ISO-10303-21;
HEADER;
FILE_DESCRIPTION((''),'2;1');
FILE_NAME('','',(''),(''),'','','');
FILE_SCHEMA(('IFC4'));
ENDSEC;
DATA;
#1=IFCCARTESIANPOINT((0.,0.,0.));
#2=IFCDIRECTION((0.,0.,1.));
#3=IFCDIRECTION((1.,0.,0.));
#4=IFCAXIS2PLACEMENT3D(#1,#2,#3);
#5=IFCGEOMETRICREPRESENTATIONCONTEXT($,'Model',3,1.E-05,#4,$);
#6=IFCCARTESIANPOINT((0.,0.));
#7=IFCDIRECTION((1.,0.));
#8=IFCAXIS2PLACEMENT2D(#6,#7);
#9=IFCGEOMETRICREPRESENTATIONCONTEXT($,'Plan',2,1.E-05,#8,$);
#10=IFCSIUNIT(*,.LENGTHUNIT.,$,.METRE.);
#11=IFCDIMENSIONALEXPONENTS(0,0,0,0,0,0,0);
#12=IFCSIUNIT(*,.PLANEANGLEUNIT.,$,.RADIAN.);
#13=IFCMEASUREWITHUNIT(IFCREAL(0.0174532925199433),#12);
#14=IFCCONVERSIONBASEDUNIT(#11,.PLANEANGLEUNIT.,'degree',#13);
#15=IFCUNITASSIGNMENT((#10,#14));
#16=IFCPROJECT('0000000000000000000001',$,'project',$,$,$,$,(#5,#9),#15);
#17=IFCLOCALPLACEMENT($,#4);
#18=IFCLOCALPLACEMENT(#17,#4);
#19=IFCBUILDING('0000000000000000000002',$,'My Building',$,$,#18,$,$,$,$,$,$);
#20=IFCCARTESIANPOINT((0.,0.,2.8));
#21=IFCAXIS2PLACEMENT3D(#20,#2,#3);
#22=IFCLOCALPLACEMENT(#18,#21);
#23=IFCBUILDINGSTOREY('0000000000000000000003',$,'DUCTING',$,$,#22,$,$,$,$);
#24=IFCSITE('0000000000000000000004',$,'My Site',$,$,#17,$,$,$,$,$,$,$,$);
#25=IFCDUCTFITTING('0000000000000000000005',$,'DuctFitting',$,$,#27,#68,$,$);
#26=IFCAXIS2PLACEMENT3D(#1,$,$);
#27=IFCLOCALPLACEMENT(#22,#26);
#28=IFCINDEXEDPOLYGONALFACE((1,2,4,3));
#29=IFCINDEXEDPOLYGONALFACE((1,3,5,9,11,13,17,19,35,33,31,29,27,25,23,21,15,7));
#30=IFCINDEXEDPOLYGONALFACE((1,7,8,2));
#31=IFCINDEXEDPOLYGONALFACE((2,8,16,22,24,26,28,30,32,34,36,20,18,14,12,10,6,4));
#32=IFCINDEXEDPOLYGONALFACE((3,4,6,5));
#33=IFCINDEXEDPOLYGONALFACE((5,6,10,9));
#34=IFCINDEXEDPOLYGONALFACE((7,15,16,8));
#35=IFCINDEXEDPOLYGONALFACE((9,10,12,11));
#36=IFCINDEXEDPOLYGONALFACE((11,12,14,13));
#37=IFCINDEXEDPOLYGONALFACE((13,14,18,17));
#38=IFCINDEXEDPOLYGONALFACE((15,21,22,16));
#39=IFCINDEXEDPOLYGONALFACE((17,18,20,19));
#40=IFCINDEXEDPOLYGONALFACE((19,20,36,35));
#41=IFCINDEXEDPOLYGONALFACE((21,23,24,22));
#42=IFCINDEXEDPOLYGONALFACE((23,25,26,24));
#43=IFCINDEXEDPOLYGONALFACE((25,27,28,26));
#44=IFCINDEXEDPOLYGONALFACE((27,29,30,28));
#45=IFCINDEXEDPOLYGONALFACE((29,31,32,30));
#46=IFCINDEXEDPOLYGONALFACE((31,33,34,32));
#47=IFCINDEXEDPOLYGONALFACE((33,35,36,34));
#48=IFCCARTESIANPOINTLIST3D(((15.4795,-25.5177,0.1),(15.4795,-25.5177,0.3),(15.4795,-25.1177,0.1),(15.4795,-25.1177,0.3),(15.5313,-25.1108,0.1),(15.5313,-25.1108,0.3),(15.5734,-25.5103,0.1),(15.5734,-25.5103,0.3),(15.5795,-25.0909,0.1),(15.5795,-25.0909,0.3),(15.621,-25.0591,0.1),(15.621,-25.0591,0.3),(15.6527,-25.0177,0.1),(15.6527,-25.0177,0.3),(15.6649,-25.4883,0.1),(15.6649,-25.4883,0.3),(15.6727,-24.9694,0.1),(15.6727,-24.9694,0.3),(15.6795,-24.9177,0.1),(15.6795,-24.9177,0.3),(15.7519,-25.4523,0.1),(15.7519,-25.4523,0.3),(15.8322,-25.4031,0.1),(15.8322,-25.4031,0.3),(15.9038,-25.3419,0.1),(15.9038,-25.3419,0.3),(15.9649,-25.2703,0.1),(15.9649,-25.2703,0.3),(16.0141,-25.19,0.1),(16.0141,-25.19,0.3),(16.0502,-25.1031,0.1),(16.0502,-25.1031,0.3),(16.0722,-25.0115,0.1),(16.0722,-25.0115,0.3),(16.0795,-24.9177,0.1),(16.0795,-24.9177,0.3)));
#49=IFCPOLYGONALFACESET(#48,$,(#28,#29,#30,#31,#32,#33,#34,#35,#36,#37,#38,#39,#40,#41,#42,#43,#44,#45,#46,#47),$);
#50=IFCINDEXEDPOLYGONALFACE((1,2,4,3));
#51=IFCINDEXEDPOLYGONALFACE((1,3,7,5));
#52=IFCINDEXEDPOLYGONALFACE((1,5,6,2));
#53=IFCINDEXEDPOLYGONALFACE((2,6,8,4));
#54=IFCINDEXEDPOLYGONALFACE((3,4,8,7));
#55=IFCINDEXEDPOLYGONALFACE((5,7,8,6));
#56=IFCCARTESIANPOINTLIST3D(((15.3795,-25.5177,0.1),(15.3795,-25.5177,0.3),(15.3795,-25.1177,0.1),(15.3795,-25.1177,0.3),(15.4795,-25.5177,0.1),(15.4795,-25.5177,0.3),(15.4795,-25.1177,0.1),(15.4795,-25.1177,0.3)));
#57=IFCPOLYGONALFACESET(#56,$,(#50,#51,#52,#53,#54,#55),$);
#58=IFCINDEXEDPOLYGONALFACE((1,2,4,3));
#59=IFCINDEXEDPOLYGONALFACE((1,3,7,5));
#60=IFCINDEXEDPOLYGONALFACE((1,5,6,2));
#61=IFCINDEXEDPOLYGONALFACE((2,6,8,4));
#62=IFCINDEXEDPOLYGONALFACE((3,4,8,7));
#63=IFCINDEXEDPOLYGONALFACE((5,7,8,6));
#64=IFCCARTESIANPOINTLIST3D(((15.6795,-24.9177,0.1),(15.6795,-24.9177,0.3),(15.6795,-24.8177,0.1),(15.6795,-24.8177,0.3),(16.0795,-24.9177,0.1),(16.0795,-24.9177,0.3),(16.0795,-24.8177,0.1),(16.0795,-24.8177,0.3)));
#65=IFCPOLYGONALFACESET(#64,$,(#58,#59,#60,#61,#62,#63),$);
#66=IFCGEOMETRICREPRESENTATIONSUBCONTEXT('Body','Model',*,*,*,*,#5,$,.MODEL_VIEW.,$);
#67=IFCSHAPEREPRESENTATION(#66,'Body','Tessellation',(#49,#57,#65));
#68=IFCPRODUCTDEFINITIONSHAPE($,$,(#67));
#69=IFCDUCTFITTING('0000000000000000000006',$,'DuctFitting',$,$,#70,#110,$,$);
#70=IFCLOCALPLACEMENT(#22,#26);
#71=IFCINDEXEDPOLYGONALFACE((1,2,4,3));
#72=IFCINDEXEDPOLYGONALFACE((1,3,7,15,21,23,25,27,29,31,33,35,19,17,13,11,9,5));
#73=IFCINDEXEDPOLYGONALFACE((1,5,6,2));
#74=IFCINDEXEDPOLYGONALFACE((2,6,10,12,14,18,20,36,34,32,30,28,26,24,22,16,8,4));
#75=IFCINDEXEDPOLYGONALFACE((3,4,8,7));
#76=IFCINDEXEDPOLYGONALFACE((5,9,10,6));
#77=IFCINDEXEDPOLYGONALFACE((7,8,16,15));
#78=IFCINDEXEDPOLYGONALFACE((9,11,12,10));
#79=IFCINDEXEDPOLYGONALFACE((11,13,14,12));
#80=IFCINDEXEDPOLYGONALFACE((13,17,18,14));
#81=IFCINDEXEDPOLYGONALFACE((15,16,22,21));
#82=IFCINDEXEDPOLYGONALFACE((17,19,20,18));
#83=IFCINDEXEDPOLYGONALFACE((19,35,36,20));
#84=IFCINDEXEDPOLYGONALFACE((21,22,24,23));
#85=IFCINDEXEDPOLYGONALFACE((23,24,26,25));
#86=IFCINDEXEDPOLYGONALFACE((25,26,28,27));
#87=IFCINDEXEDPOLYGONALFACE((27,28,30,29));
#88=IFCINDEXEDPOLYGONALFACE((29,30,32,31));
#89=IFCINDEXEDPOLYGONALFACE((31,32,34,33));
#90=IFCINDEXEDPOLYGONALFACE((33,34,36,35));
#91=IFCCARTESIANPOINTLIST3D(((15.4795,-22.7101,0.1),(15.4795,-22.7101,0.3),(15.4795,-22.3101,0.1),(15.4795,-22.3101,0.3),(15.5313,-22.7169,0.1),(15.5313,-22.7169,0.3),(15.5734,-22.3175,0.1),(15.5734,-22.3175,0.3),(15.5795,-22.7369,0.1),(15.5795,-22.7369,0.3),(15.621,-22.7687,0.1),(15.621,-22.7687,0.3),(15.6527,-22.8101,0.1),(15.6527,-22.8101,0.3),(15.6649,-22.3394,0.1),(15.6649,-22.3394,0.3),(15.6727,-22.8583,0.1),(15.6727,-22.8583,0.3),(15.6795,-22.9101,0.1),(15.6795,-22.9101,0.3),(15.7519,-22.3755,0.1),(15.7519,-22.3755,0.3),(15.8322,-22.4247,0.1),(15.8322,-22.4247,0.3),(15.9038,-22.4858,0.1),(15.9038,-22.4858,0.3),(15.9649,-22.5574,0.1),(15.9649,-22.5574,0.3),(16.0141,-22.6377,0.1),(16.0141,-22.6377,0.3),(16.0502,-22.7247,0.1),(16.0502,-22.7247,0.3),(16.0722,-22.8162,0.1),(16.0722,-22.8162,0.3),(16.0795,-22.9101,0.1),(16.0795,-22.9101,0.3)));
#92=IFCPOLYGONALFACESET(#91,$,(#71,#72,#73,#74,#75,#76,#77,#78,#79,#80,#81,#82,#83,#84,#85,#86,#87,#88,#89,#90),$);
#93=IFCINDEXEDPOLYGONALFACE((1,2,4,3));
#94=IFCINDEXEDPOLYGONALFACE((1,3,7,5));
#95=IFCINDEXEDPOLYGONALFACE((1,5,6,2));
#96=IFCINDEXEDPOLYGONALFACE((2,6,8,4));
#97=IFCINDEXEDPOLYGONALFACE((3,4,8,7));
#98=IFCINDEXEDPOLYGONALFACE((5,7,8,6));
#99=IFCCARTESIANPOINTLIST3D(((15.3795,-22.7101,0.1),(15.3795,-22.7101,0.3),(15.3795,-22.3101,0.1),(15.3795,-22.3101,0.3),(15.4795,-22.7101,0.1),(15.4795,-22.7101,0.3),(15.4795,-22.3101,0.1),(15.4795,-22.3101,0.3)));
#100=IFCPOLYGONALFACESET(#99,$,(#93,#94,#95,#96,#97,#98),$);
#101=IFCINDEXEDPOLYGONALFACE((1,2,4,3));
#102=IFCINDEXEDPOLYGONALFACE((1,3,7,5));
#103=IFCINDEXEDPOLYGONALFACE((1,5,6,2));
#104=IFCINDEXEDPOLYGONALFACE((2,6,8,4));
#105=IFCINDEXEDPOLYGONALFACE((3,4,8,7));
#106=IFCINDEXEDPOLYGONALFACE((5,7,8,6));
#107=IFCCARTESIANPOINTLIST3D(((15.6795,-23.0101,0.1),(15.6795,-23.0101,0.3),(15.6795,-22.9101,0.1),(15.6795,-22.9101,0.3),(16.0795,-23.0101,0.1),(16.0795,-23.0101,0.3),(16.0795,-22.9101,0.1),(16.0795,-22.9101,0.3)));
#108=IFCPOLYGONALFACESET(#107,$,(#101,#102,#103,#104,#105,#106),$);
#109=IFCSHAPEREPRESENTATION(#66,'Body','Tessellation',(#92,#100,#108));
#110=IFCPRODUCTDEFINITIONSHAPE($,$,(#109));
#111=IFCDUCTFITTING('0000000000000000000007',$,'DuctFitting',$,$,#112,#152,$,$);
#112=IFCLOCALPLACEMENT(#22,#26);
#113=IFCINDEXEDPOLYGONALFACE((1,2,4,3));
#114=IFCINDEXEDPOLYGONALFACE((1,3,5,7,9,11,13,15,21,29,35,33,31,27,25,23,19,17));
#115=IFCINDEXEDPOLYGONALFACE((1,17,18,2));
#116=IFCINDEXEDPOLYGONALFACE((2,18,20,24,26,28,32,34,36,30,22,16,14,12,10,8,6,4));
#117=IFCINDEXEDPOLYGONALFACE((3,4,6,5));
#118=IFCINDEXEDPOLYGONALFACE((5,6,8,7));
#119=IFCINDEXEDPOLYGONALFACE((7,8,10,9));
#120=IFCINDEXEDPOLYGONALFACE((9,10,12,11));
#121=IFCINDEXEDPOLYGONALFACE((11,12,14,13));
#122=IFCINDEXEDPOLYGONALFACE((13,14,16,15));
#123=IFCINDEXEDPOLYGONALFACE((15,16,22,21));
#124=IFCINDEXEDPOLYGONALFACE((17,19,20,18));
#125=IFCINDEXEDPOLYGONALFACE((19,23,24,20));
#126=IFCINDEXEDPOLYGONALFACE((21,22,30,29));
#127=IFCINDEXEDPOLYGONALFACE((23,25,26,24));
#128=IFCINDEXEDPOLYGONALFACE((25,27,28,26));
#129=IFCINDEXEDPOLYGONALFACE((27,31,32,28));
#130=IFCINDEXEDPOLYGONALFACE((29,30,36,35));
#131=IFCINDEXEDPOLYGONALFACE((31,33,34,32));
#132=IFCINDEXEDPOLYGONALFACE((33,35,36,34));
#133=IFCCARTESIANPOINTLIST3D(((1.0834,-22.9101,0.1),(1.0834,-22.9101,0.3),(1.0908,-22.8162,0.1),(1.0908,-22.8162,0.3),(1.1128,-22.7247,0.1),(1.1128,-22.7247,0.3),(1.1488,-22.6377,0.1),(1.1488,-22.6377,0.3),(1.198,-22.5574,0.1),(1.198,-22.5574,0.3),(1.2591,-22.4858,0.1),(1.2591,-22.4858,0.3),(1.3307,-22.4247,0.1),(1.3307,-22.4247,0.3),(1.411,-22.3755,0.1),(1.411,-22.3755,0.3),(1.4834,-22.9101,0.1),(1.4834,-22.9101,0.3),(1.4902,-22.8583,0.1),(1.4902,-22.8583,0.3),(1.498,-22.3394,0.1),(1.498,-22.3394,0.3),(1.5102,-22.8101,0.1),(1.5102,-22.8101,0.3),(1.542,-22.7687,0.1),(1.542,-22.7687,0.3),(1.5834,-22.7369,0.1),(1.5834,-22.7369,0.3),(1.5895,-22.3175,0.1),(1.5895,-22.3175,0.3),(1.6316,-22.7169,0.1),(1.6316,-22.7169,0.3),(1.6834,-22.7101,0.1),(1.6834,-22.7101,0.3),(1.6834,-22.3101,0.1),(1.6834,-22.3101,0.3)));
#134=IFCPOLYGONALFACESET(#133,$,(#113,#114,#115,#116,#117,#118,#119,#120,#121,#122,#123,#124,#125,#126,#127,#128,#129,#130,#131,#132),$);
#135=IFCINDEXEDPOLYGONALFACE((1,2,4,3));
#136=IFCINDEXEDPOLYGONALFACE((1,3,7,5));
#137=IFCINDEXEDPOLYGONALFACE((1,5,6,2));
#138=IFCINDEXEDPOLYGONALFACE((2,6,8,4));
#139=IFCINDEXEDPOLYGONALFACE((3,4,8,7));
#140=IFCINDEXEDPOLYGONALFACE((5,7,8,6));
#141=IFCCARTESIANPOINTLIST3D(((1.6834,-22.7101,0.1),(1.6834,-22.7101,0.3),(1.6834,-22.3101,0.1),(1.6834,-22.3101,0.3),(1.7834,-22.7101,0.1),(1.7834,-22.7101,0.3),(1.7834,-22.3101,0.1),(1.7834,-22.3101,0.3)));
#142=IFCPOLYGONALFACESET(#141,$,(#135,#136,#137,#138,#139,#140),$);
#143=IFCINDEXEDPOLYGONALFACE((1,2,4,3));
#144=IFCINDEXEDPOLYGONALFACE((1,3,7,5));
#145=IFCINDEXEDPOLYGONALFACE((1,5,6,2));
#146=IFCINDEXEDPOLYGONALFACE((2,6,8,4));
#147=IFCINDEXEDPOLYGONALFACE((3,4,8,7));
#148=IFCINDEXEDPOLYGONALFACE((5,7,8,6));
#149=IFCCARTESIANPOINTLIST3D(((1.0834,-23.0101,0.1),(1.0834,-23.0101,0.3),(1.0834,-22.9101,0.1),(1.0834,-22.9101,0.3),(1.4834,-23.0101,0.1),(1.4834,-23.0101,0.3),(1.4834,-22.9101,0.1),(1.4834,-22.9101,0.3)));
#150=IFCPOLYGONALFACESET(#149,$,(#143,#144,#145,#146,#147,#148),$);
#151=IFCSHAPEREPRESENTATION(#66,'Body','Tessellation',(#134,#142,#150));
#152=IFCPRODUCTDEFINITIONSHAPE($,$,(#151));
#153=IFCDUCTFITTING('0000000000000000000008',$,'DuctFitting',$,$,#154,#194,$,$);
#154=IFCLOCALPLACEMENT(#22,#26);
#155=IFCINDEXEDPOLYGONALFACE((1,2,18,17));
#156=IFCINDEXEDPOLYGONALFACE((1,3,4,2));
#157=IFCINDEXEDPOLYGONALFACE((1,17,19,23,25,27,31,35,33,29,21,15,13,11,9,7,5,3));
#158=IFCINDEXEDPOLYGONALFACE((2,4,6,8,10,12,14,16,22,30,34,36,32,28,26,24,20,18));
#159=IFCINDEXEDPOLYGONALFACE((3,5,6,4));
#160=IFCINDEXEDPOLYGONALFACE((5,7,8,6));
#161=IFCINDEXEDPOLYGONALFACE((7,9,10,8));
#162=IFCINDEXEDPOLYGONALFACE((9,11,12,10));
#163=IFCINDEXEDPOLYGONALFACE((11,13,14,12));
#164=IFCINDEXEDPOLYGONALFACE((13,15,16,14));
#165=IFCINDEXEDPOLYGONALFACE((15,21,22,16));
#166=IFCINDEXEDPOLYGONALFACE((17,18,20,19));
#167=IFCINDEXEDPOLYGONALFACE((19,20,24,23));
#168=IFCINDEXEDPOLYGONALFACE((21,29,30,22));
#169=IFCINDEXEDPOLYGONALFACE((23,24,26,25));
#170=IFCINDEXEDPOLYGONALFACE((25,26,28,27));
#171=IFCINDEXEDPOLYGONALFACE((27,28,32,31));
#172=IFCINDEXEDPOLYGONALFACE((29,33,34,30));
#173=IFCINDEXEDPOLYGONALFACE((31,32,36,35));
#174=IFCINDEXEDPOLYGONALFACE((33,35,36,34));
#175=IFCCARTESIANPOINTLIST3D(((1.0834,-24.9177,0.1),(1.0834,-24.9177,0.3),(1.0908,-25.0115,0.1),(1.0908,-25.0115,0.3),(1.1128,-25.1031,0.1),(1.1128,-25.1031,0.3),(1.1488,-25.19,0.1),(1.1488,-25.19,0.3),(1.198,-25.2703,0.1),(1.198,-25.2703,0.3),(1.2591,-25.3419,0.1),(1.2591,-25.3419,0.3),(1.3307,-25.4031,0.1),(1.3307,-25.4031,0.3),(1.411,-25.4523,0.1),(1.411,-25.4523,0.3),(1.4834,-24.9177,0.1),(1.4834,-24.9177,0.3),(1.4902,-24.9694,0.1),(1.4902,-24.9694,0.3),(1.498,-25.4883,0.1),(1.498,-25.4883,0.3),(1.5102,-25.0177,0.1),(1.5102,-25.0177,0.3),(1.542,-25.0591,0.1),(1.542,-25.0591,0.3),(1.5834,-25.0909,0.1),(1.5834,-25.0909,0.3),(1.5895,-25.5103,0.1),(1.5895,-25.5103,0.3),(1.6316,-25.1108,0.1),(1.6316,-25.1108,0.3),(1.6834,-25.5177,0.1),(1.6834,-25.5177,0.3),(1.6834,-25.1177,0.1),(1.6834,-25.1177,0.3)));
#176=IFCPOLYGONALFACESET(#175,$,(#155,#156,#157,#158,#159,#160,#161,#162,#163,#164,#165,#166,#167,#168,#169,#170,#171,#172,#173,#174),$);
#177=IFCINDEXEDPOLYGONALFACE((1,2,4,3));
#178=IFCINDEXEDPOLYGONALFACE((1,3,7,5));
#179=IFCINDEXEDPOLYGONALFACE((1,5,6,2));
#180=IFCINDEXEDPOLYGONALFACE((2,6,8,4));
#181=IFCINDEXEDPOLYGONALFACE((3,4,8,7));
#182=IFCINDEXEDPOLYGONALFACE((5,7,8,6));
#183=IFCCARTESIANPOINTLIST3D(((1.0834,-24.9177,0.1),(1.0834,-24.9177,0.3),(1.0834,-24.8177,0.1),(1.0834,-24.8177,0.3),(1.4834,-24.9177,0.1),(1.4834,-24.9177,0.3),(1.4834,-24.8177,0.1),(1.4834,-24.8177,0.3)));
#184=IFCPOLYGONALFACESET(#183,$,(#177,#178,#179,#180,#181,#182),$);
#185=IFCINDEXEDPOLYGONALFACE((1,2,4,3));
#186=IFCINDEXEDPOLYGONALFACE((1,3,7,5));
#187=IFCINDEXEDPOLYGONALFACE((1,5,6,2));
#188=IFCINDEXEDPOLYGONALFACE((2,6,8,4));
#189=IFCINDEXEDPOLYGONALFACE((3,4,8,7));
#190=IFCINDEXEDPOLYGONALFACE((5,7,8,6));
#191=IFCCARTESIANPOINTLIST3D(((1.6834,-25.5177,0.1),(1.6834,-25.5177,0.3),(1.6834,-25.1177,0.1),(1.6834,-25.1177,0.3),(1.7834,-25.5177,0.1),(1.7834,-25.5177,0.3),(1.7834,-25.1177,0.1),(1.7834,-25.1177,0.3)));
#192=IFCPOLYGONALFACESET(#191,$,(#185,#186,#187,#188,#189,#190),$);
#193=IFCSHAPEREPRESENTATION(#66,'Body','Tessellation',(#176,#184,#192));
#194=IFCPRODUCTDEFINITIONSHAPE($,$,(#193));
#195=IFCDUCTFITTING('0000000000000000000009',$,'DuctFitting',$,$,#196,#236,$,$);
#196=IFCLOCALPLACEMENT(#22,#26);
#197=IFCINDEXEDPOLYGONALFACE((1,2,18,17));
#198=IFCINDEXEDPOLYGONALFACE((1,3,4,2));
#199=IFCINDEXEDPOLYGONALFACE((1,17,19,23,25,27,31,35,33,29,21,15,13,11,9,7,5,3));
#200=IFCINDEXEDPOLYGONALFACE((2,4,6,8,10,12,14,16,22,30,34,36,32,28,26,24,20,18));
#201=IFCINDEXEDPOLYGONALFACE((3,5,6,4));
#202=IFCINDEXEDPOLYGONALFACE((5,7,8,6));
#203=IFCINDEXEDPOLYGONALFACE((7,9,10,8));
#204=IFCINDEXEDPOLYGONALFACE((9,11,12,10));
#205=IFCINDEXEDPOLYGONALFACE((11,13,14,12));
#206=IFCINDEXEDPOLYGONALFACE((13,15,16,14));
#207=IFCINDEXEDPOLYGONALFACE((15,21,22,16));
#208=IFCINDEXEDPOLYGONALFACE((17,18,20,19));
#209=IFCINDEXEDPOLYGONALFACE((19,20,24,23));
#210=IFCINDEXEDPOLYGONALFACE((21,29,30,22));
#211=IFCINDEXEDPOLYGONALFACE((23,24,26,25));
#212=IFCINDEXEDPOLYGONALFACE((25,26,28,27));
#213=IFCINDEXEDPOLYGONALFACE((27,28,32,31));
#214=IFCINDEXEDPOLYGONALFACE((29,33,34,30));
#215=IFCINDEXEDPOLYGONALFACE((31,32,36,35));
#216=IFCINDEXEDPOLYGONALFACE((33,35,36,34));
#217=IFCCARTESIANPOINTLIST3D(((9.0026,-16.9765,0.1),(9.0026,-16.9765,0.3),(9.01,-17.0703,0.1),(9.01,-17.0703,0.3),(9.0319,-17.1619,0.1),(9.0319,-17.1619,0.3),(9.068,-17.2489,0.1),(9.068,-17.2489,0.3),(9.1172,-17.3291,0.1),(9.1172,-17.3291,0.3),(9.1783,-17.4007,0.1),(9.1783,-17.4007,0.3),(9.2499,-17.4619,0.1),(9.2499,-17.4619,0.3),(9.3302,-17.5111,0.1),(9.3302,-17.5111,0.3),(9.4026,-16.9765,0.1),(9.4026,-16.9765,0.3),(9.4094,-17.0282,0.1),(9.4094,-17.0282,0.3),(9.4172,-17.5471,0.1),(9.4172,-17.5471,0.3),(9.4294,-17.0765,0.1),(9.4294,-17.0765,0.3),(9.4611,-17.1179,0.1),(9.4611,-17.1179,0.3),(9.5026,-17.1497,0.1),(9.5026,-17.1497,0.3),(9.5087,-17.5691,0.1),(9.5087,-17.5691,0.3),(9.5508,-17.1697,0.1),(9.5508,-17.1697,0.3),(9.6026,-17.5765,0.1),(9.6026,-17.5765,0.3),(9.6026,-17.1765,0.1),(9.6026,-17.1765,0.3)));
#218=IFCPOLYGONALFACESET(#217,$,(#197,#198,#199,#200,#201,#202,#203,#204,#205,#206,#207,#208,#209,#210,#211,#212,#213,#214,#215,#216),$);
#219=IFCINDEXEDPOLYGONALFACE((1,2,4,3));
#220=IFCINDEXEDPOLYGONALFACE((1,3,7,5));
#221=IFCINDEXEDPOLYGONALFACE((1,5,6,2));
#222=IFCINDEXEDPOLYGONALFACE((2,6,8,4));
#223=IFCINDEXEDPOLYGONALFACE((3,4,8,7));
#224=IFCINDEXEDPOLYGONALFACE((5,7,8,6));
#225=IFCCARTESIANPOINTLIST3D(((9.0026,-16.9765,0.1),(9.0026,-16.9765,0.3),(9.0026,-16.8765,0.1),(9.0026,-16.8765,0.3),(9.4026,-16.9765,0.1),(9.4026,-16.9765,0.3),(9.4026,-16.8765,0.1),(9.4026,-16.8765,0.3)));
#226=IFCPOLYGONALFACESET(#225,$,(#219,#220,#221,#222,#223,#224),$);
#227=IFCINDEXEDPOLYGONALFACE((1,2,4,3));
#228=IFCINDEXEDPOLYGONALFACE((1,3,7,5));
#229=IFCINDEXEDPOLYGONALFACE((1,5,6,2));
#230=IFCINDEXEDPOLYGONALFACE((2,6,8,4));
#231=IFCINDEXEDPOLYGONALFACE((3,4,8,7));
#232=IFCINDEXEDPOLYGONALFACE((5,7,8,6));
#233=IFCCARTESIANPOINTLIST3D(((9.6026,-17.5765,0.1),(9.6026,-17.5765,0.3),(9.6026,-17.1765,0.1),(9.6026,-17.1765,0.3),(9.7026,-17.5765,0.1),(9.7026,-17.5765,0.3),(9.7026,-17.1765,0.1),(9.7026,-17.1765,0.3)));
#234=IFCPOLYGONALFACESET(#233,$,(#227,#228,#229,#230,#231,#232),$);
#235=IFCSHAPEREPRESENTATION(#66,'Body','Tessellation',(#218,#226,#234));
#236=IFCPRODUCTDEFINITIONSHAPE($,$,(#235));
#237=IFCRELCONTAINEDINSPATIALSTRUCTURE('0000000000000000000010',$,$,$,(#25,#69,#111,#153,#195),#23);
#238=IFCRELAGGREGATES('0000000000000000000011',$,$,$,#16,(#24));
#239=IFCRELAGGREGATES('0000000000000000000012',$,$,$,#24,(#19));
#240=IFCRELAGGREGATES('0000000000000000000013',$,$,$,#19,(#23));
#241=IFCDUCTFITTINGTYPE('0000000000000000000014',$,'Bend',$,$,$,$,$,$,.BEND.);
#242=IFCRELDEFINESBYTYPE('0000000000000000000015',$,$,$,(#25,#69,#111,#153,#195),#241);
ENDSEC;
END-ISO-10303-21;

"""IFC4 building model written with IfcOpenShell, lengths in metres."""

from ifc_helpers import new_model, entity, si_unit, converted_unit, frame, origin_with_axes, origin_2d_with_axis, place, context, subcontext, project, spatial, line, arc, indexed_curve, rectangle, outline, extrude, source, transform, mapped, type_object, type_shapes, element, save


model = new_model("IFC4")

# Units and contexts
model_context = context("Model", 3, precision=1e-05, world=origin_with_axes())
plan_context = context("Plan", 2, precision=1e-05, world=origin_2d_with_axis())
body_context = subcontext(model_context, "Body", "Model", "MODEL_VIEW")
ifc_project = project(units=[si_unit("LENGTHUNIT", "METRE"), converted_unit("PLANEANGLEUNIT", "degree", entity("IfcReal", 0.0174532925199433), si_unit("PLANEANGLEUNIT", "RADIAN"), dimensions=[0, 0, 0, 0, 0, 0, 0])], contexts=[model_context, plan_context])

# Site, building, storey
site_placement = place(None, origin_with_axes())
site = spatial("IfcSite", under=ifc_project, at=site_placement, Name="My Site")
building_placement = place(site_placement, origin_with_axes())
building = spatial("IfcBuilding", under=site, at=building_placement, Name="My Building")
storey_placement = place(building_placement, frame((0.0, 0.0, 2.8), z_axis=(0.0, 0.0, 1.0), x_axis=(1.0, 0.0, 0.0)))
storey = spatial("IfcBuildingStorey", under=building, at=storey_placement, Name="DUCTING")

# Duct fittings
duct_fitting_type_1 = type_object("IfcDuctFittingType", Name="Bend", PredefinedType="BEND")
shared_shape = source(origin_with_axes(), body_context, "Body", "SweptSolid", [
    extrude(outline(indexed_curve([(0.2, 0.0), (0.2586, 0.1414), (0.4, 0.2), (0.4, 0.6), (-0.0243, 0.4243), (-0.2, 0.0)], segments=[arc(1, 2, 3), line(3, 4), arc(4, 5, 6), line(6, 1)])), frame((0.0, -0.1, 0.1), z_axis=(0.0, -1.0, 0.0), x_axis=(1.0, 0.0, 0.0)), (0.0, 0.0, -1.0), 0.2),
    extrude(rectangle(XDim=0.4, YDim=0.2), origin_with_axes(), (0.0, 0.0, 1.0), 0.1),
    extrude(rectangle(XDim=0.4, YDim=0.2), frame((0.4, 0.0, 0.5), z_axis=(1.0, 0.0, 0.0), x_axis=(0.0, 0.0, 1.0)), (0.0, 0.0, 1.0), 0.1),
])
type_shapes(duct_fitting_type_1, [shared_shape])
for number, where, z_axis, x_axis, name in (
    (1, (15.3795, -25.3177, 0.2), (1.0, 0.0, 0.0), (0.0, 1.0, 0.0), "DuctFitting"),
    (2, (15.3795, -22.5101, 0.2), (1.0, 0.0, 0.0), (0.0, -1.0, 0.0), "DuctFitting"),
    (3, (1.7834, -22.5101, 0.2), (-1.0, 0.0, 0.0), (0.0, -1.0, 0.0), "DuctFitting"),
    (4, (1.2834, -24.8177, 0.2), (0.0, -1.0, 0.0), (1.0, 0.0, 0.0), "DuctFitting"),
    (5, (9.2026, -16.8765, 0.2), (0.0, -1.0, 0.0), (1.0, 0.0, 0.0), "DuctFitting"),
):
    element("IfcDuctFitting", number, at=place(storey_placement, frame(where, z_axis=z_axis, x_axis=x_axis)), inside=storey, type_object=duct_fitting_type_1, Name=name, context=body_context, shape_type="MappedRepresentation", body=[
        mapped(shared_shape, transform((0.0, 0.0, 0.0), x_axis=(1.0, 0.0, 0.0), y_axis=(0.0, 1.0, 0.0), z_axis=(0.0, 0.0, 1.0), scale=1.0)),
    ])

save(model, "model.ifc")
